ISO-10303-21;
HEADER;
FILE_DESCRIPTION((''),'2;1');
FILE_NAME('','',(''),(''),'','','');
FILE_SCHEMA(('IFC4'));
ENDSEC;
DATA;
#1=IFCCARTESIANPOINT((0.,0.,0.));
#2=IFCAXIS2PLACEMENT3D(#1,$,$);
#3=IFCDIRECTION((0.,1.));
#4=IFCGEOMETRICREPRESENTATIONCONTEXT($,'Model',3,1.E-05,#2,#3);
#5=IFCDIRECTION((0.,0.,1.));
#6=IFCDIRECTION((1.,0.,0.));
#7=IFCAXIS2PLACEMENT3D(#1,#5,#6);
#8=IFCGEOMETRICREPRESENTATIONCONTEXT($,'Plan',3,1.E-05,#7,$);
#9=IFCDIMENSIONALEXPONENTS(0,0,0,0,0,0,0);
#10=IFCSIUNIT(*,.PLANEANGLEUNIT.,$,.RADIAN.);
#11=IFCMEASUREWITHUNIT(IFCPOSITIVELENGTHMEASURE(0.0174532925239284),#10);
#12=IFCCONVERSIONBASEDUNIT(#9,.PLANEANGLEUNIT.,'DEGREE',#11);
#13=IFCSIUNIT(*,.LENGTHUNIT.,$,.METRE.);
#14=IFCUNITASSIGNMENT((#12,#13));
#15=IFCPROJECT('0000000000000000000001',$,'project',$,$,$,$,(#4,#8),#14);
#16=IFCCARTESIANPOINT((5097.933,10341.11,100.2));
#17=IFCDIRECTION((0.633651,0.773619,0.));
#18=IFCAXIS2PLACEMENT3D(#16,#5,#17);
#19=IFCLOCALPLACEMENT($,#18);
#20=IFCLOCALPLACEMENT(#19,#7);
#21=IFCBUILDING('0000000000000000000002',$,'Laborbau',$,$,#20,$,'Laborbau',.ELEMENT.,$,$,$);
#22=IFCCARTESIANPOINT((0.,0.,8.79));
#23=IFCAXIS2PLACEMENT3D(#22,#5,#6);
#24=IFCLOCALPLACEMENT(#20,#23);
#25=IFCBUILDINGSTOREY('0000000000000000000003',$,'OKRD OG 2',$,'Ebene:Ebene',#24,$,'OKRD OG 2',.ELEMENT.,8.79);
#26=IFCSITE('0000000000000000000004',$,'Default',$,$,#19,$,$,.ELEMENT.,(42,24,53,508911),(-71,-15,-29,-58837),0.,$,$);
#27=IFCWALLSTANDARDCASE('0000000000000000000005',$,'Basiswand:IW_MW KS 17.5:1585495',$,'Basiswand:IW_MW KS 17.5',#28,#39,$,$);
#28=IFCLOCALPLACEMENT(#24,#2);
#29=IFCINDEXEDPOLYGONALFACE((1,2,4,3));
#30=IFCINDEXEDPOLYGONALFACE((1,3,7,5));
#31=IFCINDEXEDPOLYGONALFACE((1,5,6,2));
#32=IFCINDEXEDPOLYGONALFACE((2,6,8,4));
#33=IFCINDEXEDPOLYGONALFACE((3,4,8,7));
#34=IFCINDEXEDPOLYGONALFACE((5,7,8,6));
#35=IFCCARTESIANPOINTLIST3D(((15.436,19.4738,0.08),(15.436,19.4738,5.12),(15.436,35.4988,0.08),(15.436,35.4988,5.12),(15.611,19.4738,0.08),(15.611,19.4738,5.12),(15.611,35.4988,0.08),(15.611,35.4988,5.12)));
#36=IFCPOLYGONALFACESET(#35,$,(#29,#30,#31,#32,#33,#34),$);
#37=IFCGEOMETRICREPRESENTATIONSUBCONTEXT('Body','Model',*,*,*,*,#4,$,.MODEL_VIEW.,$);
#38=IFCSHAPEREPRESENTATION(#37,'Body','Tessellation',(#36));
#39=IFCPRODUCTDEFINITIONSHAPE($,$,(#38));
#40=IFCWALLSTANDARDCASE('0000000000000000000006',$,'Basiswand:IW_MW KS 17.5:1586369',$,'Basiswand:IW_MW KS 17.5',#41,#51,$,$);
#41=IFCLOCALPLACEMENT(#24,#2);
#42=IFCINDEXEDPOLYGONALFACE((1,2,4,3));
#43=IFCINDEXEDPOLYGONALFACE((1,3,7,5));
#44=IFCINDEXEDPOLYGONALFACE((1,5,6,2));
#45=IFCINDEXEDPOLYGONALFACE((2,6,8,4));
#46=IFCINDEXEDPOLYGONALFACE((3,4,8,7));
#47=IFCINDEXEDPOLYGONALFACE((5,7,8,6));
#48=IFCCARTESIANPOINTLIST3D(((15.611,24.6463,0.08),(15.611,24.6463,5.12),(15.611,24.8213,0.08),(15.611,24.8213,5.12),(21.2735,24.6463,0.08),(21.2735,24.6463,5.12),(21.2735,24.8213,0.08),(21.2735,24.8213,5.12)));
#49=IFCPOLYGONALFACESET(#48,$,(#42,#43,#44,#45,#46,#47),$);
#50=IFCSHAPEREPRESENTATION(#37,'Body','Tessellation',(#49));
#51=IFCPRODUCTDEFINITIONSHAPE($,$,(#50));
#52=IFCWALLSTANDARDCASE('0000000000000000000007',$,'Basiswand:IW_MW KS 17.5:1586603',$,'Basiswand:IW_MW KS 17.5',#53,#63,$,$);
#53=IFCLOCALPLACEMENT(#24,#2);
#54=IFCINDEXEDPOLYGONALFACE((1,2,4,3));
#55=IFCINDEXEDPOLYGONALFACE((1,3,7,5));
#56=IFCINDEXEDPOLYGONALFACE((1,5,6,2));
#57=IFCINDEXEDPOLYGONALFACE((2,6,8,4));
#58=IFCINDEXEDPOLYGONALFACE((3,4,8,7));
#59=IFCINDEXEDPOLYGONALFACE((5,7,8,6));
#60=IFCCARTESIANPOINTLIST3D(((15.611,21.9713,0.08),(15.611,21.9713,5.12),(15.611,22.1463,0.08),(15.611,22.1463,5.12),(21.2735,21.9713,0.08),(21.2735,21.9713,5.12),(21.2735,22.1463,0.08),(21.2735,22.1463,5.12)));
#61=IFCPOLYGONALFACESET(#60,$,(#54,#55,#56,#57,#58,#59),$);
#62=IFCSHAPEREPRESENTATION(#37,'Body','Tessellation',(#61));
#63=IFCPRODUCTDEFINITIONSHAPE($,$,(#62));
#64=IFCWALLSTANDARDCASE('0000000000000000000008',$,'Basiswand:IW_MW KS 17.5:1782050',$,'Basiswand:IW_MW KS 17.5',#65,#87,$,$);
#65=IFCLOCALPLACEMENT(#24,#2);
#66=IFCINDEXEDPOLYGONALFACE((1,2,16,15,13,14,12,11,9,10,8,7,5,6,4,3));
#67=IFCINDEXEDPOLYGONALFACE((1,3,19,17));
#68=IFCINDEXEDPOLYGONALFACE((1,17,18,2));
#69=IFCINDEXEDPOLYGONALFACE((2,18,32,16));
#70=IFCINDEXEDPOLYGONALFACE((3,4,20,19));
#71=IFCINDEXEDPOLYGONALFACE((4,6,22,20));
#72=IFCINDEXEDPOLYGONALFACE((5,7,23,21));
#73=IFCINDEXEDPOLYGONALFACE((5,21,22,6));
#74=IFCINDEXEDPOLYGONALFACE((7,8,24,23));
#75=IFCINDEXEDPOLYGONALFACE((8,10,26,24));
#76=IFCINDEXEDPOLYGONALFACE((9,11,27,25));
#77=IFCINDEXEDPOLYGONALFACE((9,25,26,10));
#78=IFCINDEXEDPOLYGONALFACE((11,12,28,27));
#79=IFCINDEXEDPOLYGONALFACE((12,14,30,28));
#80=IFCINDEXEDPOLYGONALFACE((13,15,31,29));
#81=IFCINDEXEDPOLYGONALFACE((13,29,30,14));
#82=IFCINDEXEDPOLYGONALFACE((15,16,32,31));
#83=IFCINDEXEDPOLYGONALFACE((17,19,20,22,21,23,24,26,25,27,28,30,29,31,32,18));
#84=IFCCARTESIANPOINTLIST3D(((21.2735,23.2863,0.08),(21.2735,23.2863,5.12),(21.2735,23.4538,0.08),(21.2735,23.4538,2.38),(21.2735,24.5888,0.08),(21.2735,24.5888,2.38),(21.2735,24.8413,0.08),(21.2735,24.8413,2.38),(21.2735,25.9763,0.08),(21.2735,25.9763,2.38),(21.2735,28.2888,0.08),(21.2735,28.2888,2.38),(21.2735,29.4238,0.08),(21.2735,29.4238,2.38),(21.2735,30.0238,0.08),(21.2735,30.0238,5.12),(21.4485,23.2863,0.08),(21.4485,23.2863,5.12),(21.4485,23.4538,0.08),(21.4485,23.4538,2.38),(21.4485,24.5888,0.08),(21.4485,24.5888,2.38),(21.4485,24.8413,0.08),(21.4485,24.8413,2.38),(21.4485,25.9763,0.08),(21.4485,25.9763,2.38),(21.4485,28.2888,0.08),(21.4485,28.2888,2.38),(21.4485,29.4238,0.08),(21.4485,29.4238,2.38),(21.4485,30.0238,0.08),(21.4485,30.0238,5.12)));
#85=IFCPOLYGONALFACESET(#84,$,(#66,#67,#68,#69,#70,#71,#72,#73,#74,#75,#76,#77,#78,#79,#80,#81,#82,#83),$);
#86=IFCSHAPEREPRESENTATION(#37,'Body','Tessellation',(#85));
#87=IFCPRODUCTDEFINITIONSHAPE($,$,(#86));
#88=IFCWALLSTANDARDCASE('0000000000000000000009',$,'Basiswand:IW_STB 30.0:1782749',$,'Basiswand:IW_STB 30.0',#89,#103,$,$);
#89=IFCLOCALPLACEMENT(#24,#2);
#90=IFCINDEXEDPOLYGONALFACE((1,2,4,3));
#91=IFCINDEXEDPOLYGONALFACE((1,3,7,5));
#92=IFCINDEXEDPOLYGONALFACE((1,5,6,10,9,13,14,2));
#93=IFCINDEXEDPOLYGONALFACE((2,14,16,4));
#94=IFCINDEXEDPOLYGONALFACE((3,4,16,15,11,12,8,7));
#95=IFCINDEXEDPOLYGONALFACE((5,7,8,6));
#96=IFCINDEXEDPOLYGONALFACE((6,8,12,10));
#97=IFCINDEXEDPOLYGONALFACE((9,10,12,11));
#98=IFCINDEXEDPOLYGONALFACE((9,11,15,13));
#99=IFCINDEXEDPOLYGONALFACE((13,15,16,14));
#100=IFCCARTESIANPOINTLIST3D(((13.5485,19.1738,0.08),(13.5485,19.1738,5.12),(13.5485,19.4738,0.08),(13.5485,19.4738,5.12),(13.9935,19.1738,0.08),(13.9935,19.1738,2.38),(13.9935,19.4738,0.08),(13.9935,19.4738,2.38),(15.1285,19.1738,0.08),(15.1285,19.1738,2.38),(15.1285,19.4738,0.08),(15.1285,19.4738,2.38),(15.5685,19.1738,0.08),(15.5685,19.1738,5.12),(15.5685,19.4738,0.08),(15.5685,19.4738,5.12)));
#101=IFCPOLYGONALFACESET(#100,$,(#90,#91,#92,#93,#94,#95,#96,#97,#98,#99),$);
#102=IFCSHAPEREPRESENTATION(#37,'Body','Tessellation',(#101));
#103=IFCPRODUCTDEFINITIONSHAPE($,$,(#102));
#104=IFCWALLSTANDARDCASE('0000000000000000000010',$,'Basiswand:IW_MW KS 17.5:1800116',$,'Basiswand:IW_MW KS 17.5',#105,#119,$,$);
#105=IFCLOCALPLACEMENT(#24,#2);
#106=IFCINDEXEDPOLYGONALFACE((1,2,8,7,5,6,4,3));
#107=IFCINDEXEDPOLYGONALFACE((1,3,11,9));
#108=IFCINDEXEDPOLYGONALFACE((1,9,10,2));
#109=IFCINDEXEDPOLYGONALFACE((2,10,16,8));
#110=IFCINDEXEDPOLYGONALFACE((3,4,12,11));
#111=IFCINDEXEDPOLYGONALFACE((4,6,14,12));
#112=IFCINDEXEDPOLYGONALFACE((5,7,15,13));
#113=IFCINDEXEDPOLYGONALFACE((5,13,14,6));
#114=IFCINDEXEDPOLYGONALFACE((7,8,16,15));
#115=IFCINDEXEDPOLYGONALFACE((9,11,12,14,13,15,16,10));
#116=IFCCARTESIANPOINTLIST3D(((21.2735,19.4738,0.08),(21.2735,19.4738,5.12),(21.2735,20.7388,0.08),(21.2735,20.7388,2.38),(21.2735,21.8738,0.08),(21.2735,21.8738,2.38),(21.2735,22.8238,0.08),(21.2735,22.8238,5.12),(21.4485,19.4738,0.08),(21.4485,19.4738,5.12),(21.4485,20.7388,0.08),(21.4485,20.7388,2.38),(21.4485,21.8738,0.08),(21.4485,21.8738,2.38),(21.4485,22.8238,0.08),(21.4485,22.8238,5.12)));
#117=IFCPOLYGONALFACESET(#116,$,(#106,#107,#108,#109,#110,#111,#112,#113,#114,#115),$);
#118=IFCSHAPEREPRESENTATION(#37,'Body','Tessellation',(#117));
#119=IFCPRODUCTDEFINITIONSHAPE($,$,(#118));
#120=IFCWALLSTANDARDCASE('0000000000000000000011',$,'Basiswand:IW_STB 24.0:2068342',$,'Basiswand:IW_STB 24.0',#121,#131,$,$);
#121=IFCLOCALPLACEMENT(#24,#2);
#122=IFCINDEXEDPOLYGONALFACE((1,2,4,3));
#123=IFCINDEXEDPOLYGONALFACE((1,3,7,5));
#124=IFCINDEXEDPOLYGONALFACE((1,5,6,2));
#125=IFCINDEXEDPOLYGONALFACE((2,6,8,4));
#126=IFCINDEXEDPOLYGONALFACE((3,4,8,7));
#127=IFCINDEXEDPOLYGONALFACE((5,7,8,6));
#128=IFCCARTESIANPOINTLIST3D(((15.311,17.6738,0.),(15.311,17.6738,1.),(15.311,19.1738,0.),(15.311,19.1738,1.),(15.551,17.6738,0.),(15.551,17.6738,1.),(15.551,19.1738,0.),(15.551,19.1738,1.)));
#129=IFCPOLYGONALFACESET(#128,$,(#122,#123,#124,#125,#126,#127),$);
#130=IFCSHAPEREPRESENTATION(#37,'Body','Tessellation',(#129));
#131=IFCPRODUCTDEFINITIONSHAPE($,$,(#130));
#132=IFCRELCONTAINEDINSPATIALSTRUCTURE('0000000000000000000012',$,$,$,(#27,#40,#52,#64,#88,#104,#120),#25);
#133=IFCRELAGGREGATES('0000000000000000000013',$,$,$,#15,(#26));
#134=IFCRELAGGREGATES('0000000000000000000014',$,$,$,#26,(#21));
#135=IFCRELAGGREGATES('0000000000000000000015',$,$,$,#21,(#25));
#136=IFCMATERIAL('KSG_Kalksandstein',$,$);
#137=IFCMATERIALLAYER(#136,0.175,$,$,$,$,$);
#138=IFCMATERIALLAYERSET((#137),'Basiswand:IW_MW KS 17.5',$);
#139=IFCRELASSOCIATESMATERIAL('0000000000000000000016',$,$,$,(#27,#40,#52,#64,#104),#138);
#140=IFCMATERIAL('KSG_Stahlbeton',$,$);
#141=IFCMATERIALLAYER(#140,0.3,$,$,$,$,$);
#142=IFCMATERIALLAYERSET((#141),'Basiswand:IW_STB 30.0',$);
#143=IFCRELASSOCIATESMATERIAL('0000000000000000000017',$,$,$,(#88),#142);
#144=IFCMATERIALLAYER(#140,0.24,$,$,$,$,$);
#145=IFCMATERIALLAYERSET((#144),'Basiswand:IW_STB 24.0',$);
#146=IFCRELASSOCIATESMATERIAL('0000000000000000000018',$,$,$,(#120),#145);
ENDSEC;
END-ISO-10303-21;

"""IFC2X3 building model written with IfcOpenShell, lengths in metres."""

from ifc_helpers import new_model, entity, si_unit, converted_unit, direction, frame, frame_2d, origin, origin_with_axes, place, context, subcontext, project, spatial, rectangle, extrude, material, layer, layer_set, layer_usage, element, save


model = new_model("IFC2X3")

# Units and contexts
model_context = context("Model", 3, precision=1e-05, world=origin(), true_north=direction((0.0, 1.0)))
plan_context = context("Plan", 3, precision=1e-05, world=origin_with_axes())
body_context = subcontext(model_context, "Body", "Model", "MODEL_VIEW")
ifc_project = project(units=[converted_unit("PLANEANGLEUNIT", "DEGREE", entity("IfcPositiveLengthMeasure", 0.0174532925239284), si_unit("PLANEANGLEUNIT", "RADIAN"), dimensions=[0, 0, 0, 0, 0, 0, 0]), si_unit("LENGTHUNIT", "METRE")], contexts=[model_context, plan_context])

# Site, building, storey
site_placement = place(None, frame((5097.933, 10341.11, 100.2), z_axis=(0.0, 0.0, 1.0), x_axis=(0.633651, 0.773619, 0.0)))
site = spatial("IfcSite", under=ifc_project, at=site_placement, Name="Default", CompositionType="ELEMENT", RefLatitude=(42, 24, 53, 508911), RefLongitude=(-71, -15, -29, -58837), RefElevation=0.0)
building_placement = place(site_placement, origin_with_axes())
building = spatial("IfcBuilding", under=site, at=building_placement, Name="Laborbau", LongName="Laborbau", CompositionType="ELEMENT")
storey_placement = place(building_placement, frame((0.0, 0.0, 8.79), z_axis=(0.0, 0.0, 1.0), x_axis=(1.0, 0.0, 0.0)))
storey = spatial("IfcBuildingStorey", under=building, at=storey_placement, Name="OKRD OG 2", ObjectType="Ebene:Ebene", LongName="OKRD OG 2", CompositionType="ELEMENT", Elevation=8.79)

# Walls
ifc_material_1 = material(Name="KSG_Kalksandstein")
ifc_layer_1 = layer(ifc_material_1, 0.175)
ifc_layer_set_1 = layer_set([ifc_layer_1], Name="Basiswand:IW_MW KS 17.5")
ifc_layer_usage_1 = layer_usage(ifc_layer_set_1, "AXIS2", "NEGATIVE", 0.0875)
wall_1_placement = place(storey_placement, frame((15.5235, 19.4738, 0.08), z_axis=(0.0, 0.0, 1.0), x_axis=(0.0, 1.0, 0.0)))
element("IfcWallStandardCase", 1, at=wall_1_placement, inside=storey, material=ifc_layer_usage_1, Name="Basiswand:IW_MW KS 17.5:1585495", ObjectType="Basiswand:IW_MW KS 17.5", context=body_context, shape_type="SweptSolid", body=[
    extrude(rectangle(XDim=16.025, YDim=0.175, at=frame_2d((8.0125, 0.0), x_axis=(-1.0, 0.0))), origin(), (0.0, 0.0, 1.0), 5.04),
])
ifc_layer_usage_2 = layer_usage(ifc_layer_set_1, "AXIS2", "NEGATIVE", 0.0875)
wall_2_placement = place(storey_placement, frame((15.611, 24.7338, 0.08), z_axis=(0.0, 0.0, 1.0), x_axis=(1.0, 0.0, 0.0)))
element("IfcWallStandardCase", 2, at=wall_2_placement, inside=storey, material=ifc_layer_usage_2, Name="Basiswand:IW_MW KS 17.5:1586369", ObjectType="Basiswand:IW_MW KS 17.5", context=body_context, shape_type="SweptSolid", body=[
    extrude(rectangle(XDim=5.6625, YDim=0.175, at=frame_2d((2.8312, 0.0), x_axis=(-1.0, 0.0))), origin(), (0.0, 0.0, 1.0), 5.04),
])
ifc_layer_usage_3 = layer_usage(ifc_layer_set_1, "AXIS2", "NEGATIVE", 0.0875)
wall_3_placement = place(storey_placement, frame((15.611, 22.0588, 0.08), z_axis=(0.0, 0.0, 1.0), x_axis=(1.0, 0.0, 0.0)))
element("IfcWallStandardCase", 3, at=wall_3_placement, inside=storey, material=ifc_layer_usage_3, Name="Basiswand:IW_MW KS 17.5:1586603", ObjectType="Basiswand:IW_MW KS 17.5", context=body_context, shape_type="SweptSolid", body=[
    extrude(rectangle(XDim=5.6625, YDim=0.175, at=frame_2d((2.8312, 0.0), x_axis=(-1.0, 0.0))), origin(), (0.0, 0.0, 1.0), 5.04),
])

# Walls, openings
ifc_layer_usage_4 = layer_usage(ifc_layer_set_1, "AXIS2", "NEGATIVE", 0.0875)
wall_4_placement = place(storey_placement, frame((21.361, 23.2863, 0.08), z_axis=(0.0, 0.0, 1.0), x_axis=(0.0, 1.0, 0.0)))
wall_4 = element("IfcWallStandardCase", 4, at=wall_4_placement, inside=storey, material=ifc_layer_usage_4, Name="Basiswand:IW_MW KS 17.5:1782050", ObjectType="Basiswand:IW_MW KS 17.5", context=body_context, shape_type="SweptSolid", body=[
    extrude(rectangle(XDim=6.7375, YDim=0.175, at=frame_2d((3.3687, 0.0), x_axis=(-1.0, 0.0))), origin(), (0.0, 0.0, 1.0), 5.04),
])
opening_1_placement = place(wall_4_placement, frame((1.3025, 0.0875, -0.08), z_axis=(0.0, 0.0, 1.0), x_axis=(1.0, 0.0, 0.0)))
element("IfcOpeningElement", 5, at=opening_1_placement, cuts=wall_4, ObjectType="Opening", context=body_context, shape_type="SweptSolid", body=[
    extrude(rectangle(XDim=2.38, YDim=1.135, at=frame_2d((1.19, 0.5675), x_axis=(1.0, 0.0))), frame((0.0, 0.0, 0.0), z_axis=(0.0, -1.0, 0.0), x_axis=(0.0, 0.0, 1.0)), (0.0, 0.0, 1.0), 0.175),
])
opening_2_placement = place(wall_4_placement, frame((-23.2863, 21.361, -0.08), z_axis=(0.0, 0.0, 1.0), x_axis=(0.0, -1.0, 0.0)))
element("IfcOpeningElement", 6, at=opening_2_placement, cuts=wall_4, ObjectType="Opening", context=body_context, shape_type="SweptSolid", body=[
    extrude(rectangle(XDim=2.38, YDim=1.135, at=frame_2d((0.0, 0.0), x_axis=(1.0, 0.0))), frame((22.7975, 24.0213, 1.19), z_axis=(-1.0, 0.0, 0.0), x_axis=(0.0, 0.0, 1.0)), (0.0, 0.0, 1.0), 3.048),
])
opening_3_placement = place(wall_4_placement, frame((2.69, 0.0875, -0.08), z_axis=(0.0, 0.0, 1.0), x_axis=(1.0, 0.0, 0.0)))
element("IfcOpeningElement", 7, at=opening_3_placement, cuts=wall_4, ObjectType="Opening", context=body_context, shape_type="SweptSolid", body=[
    extrude(rectangle(XDim=2.38, YDim=1.135, at=frame_2d((1.19, 0.5675), x_axis=(1.0, 0.0))), frame((0.0, 0.0, 0.0), z_axis=(0.0, -1.0, 0.0), x_axis=(0.0, 0.0, 1.0)), (0.0, 0.0, 1.0), 0.175),
])
opening_4_placement = place(wall_4_placement, frame((-23.2863, 21.361, -0.08), z_axis=(0.0, 0.0, 1.0), x_axis=(0.0, -1.0, 0.0)))
element("IfcOpeningElement", 8, at=opening_4_placement, cuts=wall_4, ObjectType="Opening", context=body_context, shape_type="SweptSolid", body=[
    extrude(rectangle(XDim=2.38, YDim=1.135, at=frame_2d((0.0, 0.0), x_axis=(0.0, 1.0))), frame((22.7975, 25.4088, 1.19), z_axis=(-1.0, 0.0, 0.0), x_axis=(0.0, -1.0, 0.0)), (0.0, 0.0, 1.0), 3.048),
])
opening_5_placement = place(wall_4_placement, frame((6.1375, 0.0875, -0.08), z_axis=(0.0, 0.0, 1.0), x_axis=(1.0, 0.0, 0.0)))
element("IfcOpeningElement", 9, at=opening_5_placement, cuts=wall_4, ObjectType="Opening", context=body_context, shape_type="SweptSolid", body=[
    extrude(rectangle(XDim=2.38, YDim=1.135, at=frame_2d((1.19, 0.5675), x_axis=(1.0, 0.0))), frame((0.0, 0.0, 0.0), z_axis=(0.0, -1.0, 0.0), x_axis=(0.0, 0.0, 1.0)), (0.0, 0.0, 1.0), 0.175),
])
opening_6_placement = place(wall_4_placement, frame((-23.2863, 21.361, -0.08), z_axis=(0.0, 0.0, 1.0), x_axis=(0.0, -1.0, 0.0)))
element("IfcOpeningElement", 10, at=opening_6_placement, cuts=wall_4, ObjectType="Opening", context=body_context, shape_type="SweptSolid", body=[
    extrude(rectangle(XDim=2.38, YDim=1.135, at=frame_2d((0.0, 0.0), x_axis=(1.0, 0.0))), frame((22.7975, 28.8563, 1.19), z_axis=(-1.0, 0.0, 0.0), x_axis=(0.0, 0.0, 1.0)), (0.0, 0.0, 1.0), 3.048),
])
ifc_material_2 = material(Name="KSG_Stahlbeton")
ifc_layer_2 = layer(ifc_material_2, 0.3)
ifc_layer_set_2 = layer_set([ifc_layer_2], Name="Basiswand:IW_STB 30.0")
ifc_layer_usage_5 = layer_usage(ifc_layer_set_2, "AXIS2", "POSITIVE", -0.15)
wall_5_placement = place(storey_placement, frame((15.5685, 19.3238, 0.08), z_axis=(0.0, 0.0, 1.0), x_axis=(-1.0, 0.0, 0.0)))
wall_5 = element("IfcWallStandardCase", 11, at=wall_5_placement, inside=storey, material=ifc_layer_usage_5, Name="Basiswand:IW_STB 30.0:1782749", ObjectType="Basiswand:IW_STB 30.0", context=body_context, shape_type="SweptSolid", body=[
    extrude(rectangle(XDim=2.02, YDim=0.3, at=frame_2d((1.01, 0.0), x_axis=(-1.0, 0.0))), origin(), (0.0, 0.0, 1.0), 5.04),
])
opening_7_placement = place(wall_5_placement, frame((0.44, -0.15, -0.08), z_axis=(0.0, 0.0, 1.0), x_axis=(1.0, 0.0, 0.0)))
element("IfcOpeningElement", 12, at=opening_7_placement, cuts=wall_5, ObjectType="Opening", context=body_context, shape_type="SweptSolid", body=[
    extrude(rectangle(XDim=2.38, YDim=1.135, at=frame_2d((1.19, 0.5675), x_axis=(1.0, 0.0))), frame((0.0, 0.0, 0.0), z_axis=(0.0, 1.0, 0.0), x_axis=(0.0, 0.0, 1.0)), (0.0, 0.0, 1.0), 0.3),
])
opening_8_placement = place(wall_5_placement, frame((15.5685, 19.3238, -0.08), z_axis=(0.0, 0.0, 1.0), x_axis=(-1.0, 0.0, 0.0)))
element("IfcOpeningElement", 13, at=opening_8_placement, cuts=wall_5, ObjectType="Opening", context=body_context, shape_type="SweptSolid", body=[
    extrude(rectangle(XDim=2.38, YDim=1.135, at=frame_2d((0.0, 0.0), x_axis=(1.0, 0.0))), frame((14.561, 20.9978, 1.19), z_axis=(0.0, -1.0, 0.0), x_axis=(0.0, 0.0, 1.0)), (0.0, 0.0, 1.0), 3.048),
])
ifc_layer_usage_6 = layer_usage(ifc_layer_set_1, "AXIS2", "NEGATIVE", 0.0875)
wall_6_placement = place(storey_placement, frame((21.361, 22.8238, 0.08), z_axis=(0.0, 0.0, 1.0), x_axis=(0.0, -1.0, 0.0)))
wall_6 = element("IfcWallStandardCase", 14, at=wall_6_placement, inside=storey, material=ifc_layer_usage_6, Name="Basiswand:IW_MW KS 17.5:1800116", ObjectType="Basiswand:IW_MW KS 17.5", context=body_context, shape_type="SweptSolid", body=[
    extrude(rectangle(XDim=3.35, YDim=0.175, at=frame_2d((1.675, 0.0), x_axis=(-1.0, 0.0))), origin(), (0.0, 0.0, 1.0), 5.04),
])
opening_9_placement = place(wall_6_placement, frame((22.8238, -21.361, -0.08), z_axis=(0.0, 0.0, 1.0), x_axis=(0.0, 1.0, 0.0)))
element("IfcOpeningElement", 15, at=opening_9_placement, cuts=wall_6, ObjectType="Opening", context=body_context, shape_type="SweptSolid", body=[
    extrude(rectangle(XDim=2.38, YDim=1.135, at=frame_2d((0.0, 0.0), x_axis=(0.0, 1.0))), frame((19.7495, 21.3063, 1.19), z_axis=(1.0, 0.0, 0.0), x_axis=(0.0, 1.0, 0.0)), (0.0, 0.0, 1.0), 3.048),
])
opening_10_placement = place(wall_6_placement, frame((0.95, -0.0875, -0.08), z_axis=(0.0, 0.0, 1.0), x_axis=(1.0, 0.0, 0.0)))
element("IfcOpeningElement", 16, at=opening_10_placement, cuts=wall_6, ObjectType="Opening", context=body_context, shape_type="SweptSolid", body=[
    extrude(rectangle(XDim=2.38, YDim=1.135, at=frame_2d((1.19, 0.5675), x_axis=(1.0, 0.0))), frame((0.0, 0.0, 0.0), z_axis=(0.0, 1.0, 0.0), x_axis=(0.0, 0.0, 1.0)), (0.0, 0.0, 1.0), 0.175),
])

# Wall
ifc_layer_3 = layer(ifc_material_2, 0.24)
ifc_layer_set_3 = layer_set([ifc_layer_3], Name="Basiswand:IW_STB 24.0")
ifc_layer_usage_7 = layer_usage(ifc_layer_set_3, "AXIS2", "NEGATIVE", 0.12)
wall_7_placement = place(storey_placement, frame((15.431, 19.1738, 0.0), z_axis=(0.0, 0.0, 1.0), x_axis=(0.0, -1.0, 0.0)))
element("IfcWallStandardCase", 17, at=wall_7_placement, inside=storey, material=ifc_layer_usage_7, Name="Basiswand:IW_STB 24.0:2068342", ObjectType="Basiswand:IW_STB 24.0", context=body_context, shape_type="SweptSolid", body=[
    extrude(rectangle(XDim=1.5, YDim=0.24, at=frame_2d((0.75, 0.0), x_axis=(-1.0, 0.0))), origin(), (0.0, 0.0, 1.0), 1.0),
])

save(model, "model.ifc")
